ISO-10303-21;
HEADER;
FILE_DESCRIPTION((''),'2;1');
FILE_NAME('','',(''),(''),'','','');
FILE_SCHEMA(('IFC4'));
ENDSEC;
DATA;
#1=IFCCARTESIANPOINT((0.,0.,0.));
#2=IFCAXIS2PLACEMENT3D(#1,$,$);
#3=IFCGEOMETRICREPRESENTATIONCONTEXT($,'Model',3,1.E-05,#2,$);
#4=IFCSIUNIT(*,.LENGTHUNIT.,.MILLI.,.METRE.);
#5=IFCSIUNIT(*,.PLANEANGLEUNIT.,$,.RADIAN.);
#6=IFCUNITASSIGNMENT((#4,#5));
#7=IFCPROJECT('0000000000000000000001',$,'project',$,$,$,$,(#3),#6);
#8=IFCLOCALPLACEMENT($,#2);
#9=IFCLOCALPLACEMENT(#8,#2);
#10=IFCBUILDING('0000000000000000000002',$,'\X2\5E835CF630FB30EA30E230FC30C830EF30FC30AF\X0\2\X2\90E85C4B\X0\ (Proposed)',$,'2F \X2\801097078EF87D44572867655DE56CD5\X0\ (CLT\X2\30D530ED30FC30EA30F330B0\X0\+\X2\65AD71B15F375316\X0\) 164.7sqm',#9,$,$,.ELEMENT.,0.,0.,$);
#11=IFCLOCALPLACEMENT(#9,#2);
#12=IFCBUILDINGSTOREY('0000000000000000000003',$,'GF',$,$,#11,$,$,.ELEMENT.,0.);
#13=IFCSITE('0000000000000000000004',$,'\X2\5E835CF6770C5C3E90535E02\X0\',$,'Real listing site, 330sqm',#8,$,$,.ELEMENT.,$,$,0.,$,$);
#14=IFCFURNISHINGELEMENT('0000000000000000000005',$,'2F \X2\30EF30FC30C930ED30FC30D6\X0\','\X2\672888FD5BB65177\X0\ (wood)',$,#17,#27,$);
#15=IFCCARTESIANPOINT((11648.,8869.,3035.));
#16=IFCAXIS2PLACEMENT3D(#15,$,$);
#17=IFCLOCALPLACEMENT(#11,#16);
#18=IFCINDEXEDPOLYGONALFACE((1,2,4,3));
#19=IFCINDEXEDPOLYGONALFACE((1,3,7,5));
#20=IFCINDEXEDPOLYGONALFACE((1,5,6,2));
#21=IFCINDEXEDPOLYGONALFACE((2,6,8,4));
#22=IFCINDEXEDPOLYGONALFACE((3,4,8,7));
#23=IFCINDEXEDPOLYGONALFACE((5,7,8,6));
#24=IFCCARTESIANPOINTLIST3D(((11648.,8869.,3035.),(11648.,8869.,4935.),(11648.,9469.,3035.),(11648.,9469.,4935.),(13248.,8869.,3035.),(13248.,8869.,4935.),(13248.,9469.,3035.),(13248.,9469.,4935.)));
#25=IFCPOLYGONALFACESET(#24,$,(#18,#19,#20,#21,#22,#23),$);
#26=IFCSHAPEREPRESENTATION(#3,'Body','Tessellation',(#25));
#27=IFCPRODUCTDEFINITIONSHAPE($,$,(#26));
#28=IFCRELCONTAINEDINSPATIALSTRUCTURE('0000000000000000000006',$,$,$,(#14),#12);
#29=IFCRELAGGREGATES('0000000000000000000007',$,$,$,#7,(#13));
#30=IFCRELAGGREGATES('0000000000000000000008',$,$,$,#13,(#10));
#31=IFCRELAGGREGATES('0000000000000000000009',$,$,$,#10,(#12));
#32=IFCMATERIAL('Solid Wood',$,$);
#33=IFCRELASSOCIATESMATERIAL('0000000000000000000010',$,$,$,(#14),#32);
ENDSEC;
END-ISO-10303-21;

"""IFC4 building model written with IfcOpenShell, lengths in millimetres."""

from ifc_helpers import new_model, si_unit, frame, frame_2d, origin, place, context, project, spatial, rectangle, extrude, material, element, save


model = new_model("IFC4")

# Units and contexts
model_context = context("Model", 3, precision=1e-05, world=origin())
ifc_project = project(units=[si_unit("LENGTHUNIT", "METRE", prefix="MILLI"), si_unit("PLANEANGLEUNIT", "RADIAN")], contexts=[model_context])

# Site, building, storey
site_placement = place(None, origin())
site = spatial("IfcSite", under=ifc_project, at=site_placement, Name="広島県尾道市", ObjectType="Real listing site, 330sqm", CompositionType="ELEMENT", RefElevation=0.0)
building_placement = place(site_placement, origin())
building = spatial("IfcBuilding", under=site, at=building_placement, Name="広島・リモートワーク2部屋 (Proposed)", ObjectType="2F 耐震軸組在来工法 (CLTフローリング+断熱強化) 164.7sqm", CompositionType="ELEMENT", ElevationOfRefHeight=0.0, ElevationOfTerrain=0.0)
storey_placement = place(building_placement, origin())
storey = spatial("IfcBuildingStorey", under=building, at=storey_placement, Name="GF", CompositionType="ELEMENT", Elevation=0.0)

# Shared definitions
ifc_material_1 = material(Name="Solid Wood")

# Furnishing element
furnishing_1_placement = place(storey_placement, frame((11648.0, 8869.0, 3035.0)))
element("IfcFurnishingElement", 1, at=furnishing_1_placement, inside=storey, material=ifc_material_1, Name="2F ワードローブ", Description="木製家具 (wood)", context=model_context, shape_type="SweptSolid", body=[
    extrude(rectangle(XDim=1600.0, YDim=600.0, at=frame_2d((800.0, 300.0))), frame((11648.0, 8869.0, 3035.0)), (0.0, 0.0, 1.0), 1900.0),
])

save(model, "model.ifc")
